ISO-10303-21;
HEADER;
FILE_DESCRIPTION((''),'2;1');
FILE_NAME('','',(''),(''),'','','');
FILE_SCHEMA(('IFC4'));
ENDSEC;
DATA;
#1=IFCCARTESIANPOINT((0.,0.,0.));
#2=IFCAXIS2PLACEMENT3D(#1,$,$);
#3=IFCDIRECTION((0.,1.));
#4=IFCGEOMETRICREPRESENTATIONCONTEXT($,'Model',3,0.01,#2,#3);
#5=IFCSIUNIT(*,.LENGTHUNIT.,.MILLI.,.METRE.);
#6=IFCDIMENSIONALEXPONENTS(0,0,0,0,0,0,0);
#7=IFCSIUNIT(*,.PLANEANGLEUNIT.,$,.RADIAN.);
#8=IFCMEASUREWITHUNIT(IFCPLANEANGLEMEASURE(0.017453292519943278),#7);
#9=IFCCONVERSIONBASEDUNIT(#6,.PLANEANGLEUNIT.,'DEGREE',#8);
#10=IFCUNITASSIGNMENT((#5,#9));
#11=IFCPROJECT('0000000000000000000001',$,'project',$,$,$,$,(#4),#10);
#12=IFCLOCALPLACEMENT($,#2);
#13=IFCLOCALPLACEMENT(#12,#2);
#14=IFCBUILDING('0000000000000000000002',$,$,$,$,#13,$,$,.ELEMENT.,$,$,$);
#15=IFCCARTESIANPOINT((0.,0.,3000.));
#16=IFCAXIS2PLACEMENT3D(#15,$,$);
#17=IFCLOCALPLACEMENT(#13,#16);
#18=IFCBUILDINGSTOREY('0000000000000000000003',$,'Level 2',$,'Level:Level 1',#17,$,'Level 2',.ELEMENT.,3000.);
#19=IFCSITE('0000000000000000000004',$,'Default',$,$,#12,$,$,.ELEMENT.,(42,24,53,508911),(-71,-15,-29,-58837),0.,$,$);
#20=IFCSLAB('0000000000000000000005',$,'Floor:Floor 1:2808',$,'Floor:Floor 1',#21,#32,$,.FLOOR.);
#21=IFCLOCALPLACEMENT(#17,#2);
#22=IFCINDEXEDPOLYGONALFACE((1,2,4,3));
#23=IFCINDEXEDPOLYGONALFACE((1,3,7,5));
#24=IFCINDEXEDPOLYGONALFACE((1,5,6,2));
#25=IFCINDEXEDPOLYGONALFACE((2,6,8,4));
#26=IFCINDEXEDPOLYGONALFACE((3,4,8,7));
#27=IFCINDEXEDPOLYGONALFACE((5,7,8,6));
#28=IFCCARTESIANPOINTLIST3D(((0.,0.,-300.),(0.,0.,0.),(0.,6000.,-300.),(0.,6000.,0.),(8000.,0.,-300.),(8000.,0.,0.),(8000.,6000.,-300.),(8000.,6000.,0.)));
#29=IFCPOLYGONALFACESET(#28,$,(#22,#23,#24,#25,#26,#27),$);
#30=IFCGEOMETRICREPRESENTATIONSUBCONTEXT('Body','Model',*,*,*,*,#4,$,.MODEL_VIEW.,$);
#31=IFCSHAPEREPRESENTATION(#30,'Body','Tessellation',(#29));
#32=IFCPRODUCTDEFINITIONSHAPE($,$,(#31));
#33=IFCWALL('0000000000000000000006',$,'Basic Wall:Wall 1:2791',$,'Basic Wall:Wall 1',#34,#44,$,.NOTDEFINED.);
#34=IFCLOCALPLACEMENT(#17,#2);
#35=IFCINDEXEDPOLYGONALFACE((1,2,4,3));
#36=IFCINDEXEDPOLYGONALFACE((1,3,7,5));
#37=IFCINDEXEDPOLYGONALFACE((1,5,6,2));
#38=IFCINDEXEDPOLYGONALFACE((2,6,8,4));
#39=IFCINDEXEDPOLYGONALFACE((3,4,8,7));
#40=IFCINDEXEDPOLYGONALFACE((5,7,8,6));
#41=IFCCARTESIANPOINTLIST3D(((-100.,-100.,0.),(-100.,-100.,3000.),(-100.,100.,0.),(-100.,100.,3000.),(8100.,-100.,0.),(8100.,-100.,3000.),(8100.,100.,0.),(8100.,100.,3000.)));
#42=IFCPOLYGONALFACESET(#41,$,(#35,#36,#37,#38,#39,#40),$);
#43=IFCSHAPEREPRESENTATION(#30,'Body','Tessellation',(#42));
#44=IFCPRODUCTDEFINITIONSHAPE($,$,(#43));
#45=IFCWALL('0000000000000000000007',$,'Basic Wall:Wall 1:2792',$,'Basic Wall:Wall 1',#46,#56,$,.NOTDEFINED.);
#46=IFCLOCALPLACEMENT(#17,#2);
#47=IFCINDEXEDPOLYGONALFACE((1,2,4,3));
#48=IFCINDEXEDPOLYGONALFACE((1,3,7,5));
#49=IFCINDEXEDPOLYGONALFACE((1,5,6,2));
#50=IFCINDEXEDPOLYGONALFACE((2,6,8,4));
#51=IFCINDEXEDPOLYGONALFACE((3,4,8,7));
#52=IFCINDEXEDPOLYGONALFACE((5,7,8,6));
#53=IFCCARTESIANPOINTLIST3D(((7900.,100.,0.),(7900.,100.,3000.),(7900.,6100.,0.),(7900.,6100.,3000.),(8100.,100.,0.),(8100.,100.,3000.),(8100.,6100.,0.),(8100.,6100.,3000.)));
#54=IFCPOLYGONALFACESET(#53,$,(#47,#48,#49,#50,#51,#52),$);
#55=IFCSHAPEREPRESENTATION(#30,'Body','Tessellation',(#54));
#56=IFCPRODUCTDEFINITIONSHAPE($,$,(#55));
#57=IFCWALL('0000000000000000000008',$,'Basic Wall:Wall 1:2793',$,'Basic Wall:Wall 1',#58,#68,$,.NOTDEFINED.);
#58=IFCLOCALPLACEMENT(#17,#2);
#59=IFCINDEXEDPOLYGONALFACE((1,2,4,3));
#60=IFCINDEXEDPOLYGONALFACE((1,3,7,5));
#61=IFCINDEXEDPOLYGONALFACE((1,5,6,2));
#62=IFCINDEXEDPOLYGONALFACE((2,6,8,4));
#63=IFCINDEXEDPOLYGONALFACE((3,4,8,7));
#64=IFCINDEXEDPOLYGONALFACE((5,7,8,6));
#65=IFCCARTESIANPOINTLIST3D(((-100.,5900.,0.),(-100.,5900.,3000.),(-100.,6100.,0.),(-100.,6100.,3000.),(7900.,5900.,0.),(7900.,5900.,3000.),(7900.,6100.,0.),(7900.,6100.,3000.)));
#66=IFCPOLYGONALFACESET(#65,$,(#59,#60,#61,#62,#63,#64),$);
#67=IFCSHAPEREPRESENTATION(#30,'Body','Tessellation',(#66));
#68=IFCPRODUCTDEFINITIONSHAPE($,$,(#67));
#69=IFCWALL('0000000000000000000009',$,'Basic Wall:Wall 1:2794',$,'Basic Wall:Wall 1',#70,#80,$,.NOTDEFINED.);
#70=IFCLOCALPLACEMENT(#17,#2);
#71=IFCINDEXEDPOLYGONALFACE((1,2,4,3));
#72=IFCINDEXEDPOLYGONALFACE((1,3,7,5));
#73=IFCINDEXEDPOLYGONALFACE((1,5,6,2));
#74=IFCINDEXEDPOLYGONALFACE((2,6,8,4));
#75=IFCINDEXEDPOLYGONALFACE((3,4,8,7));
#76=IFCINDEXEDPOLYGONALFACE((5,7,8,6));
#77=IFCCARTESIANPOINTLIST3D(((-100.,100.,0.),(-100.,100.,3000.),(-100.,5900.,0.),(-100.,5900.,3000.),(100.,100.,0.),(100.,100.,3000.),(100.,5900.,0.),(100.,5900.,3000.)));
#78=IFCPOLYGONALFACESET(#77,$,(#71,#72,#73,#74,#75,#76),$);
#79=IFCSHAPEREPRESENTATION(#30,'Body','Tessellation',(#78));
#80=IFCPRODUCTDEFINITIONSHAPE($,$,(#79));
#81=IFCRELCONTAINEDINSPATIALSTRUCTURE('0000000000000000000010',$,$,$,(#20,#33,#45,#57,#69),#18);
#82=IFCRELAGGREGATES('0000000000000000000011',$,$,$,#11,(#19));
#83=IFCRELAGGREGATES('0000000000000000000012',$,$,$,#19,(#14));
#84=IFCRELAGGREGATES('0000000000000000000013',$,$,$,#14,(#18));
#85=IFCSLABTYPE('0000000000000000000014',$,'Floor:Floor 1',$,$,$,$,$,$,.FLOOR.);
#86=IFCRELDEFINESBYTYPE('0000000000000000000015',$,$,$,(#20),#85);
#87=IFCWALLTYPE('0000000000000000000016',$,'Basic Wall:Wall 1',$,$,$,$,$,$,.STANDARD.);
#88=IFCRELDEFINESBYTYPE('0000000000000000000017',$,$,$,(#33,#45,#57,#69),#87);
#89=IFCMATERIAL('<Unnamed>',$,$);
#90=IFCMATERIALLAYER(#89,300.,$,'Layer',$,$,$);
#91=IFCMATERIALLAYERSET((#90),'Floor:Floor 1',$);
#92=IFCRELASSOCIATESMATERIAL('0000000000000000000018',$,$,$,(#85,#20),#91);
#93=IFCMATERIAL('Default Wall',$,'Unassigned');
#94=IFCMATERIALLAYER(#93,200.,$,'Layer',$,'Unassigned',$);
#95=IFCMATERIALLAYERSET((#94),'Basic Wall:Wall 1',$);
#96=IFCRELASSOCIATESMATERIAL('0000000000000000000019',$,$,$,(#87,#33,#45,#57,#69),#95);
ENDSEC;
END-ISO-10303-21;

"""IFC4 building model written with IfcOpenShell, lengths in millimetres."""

from ifc_helpers import new_model, entity, si_unit, converted_unit, direction, frame, frame_2d, origin, origin_2d_with_axis, place, context, subcontext, project, spatial, rectangle, extrude, material, layer, layer_set, layer_usage, type_object, element, save


model = new_model("IFC4")

# Units and contexts
model_context = context("Model", 3, precision=0.01, world=origin(), true_north=direction((0.0, 1.0)))
body_context = subcontext(model_context, "Body", "Model", "MODEL_VIEW")
ifc_project = project(units=[si_unit("LENGTHUNIT", "METRE", prefix="MILLI"), converted_unit("PLANEANGLEUNIT", "DEGREE", entity("IfcPlaneAngleMeasure", 0.017453292519943278), si_unit("PLANEANGLEUNIT", "RADIAN"), dimensions=[0, 0, 0, 0, 0, 0, 0])], contexts=[model_context])

# Site, building, storey
site_placement = place(None, origin())
site = spatial("IfcSite", under=ifc_project, at=site_placement, Name="Default", CompositionType="ELEMENT", RefLatitude=(42, 24, 53, 508911), RefLongitude=(-71, -15, -29, -58837), RefElevation=0.0)
building_placement = place(site_placement, origin())
building = spatial("IfcBuilding", under=site, at=building_placement, CompositionType="ELEMENT")
storey_placement = place(building_placement, frame((0.0, 0.0, 3000.0)))
storey = spatial("IfcBuildingStorey", under=building, at=storey_placement, Name="Level 2", ObjectType="Level:Level 1", LongName="Level 2", CompositionType="ELEMENT", Elevation=3000.0)

# Slab
ifc_material_1 = material(Name="<Unnamed>")
ifc_layer_1 = layer(ifc_material_1, 300.0, Name="Layer")
ifc_layer_set_1 = layer_set([ifc_layer_1], Name="Floor:Floor 1")
ifc_layer_usage_1 = layer_usage(ifc_layer_set_1, "AXIS3", "POSITIVE", 0.0)
slab_type = type_object("IfcSlabType", Name="Floor:Floor 1", PredefinedType="FLOOR", material=ifc_layer_set_1)
slab_placement = place(storey_placement, origin())
element("IfcSlab", 1, at=slab_placement, inside=storey, type_object=slab_type, material=ifc_layer_usage_1, Name="Floor:Floor 1:2808", ObjectType="Floor:Floor 1", PredefinedType="FLOOR", context=body_context, shape_type="SweptSolid", body=[
    extrude(rectangle(XDim=6000.0, YDim=8000.0, at=origin_2d_with_axis()), frame((4000.0, 3000.0, 0.0), z_axis=(0.0, 0.0, -1.0), x_axis=(0.0, 1.0, 0.0)), (0.0, 0.0, 1.0), 300.0),
])

# Walls
ifc_material_2 = material(Name="Default Wall", Category="Unassigned")
ifc_layer_2 = layer(ifc_material_2, 200.0, Name="Layer", Category="Unassigned")
ifc_layer_set_2 = layer_set([ifc_layer_2], Name="Basic Wall:Wall 1")
ifc_layer_usage_2 = layer_usage(ifc_layer_set_2, "AXIS2", "NEGATIVE", 100.0)
wall_type = type_object("IfcWallType", Name="Basic Wall:Wall 1", PredefinedType="STANDARD", material=ifc_layer_set_2)
wall_1_placement = place(storey_placement, frame((-100.0, 0.0, 0.0)))
element("IfcWall", 2, at=wall_1_placement, inside=storey, type_object=wall_type, material=ifc_layer_usage_2, Name="Basic Wall:Wall 1:2791", ObjectType="Basic Wall:Wall 1", PredefinedType="NOTDEFINED", context=body_context, shape_type="SweptSolid", body=[
    extrude(rectangle(XDim=8200.0, YDim=200.0, at=frame_2d((4100.0, 0.0), x_axis=(-1.0, 0.0))), origin(), (0.0, 0.0, 1.0), 3000.0),
])
ifc_layer_usage_3 = layer_usage(ifc_layer_set_2, "AXIS2", "NEGATIVE", 100.0)
wall_2_placement = place(storey_placement, frame((8000.0, 100.0, 0.0), z_axis=(0.0, 0.0, 1.0), x_axis=(0.0, 1.0, 0.0)))
element("IfcWall", 3, at=wall_2_placement, inside=storey, type_object=wall_type, material=ifc_layer_usage_3, Name="Basic Wall:Wall 1:2792", ObjectType="Basic Wall:Wall 1", PredefinedType="NOTDEFINED", context=body_context, shape_type="SweptSolid", body=[
    extrude(rectangle(XDim=6000.0, YDim=200.0, at=frame_2d((3000.0, 0.0), x_axis=(-1.0, 0.0))), origin(), (0.0, 0.0, 1.0), 3000.0),
])
ifc_layer_usage_4 = layer_usage(ifc_layer_set_2, "AXIS2", "NEGATIVE", 100.0)
wall_3_placement = place(storey_placement, frame((7900.0, 6000.0, 0.0), z_axis=(0.0, 0.0, 1.0), x_axis=(-1.0, 0.0, 0.0)))
element("IfcWall", 4, at=wall_3_placement, inside=storey, type_object=wall_type, material=ifc_layer_usage_4, Name="Basic Wall:Wall 1:2793", ObjectType="Basic Wall:Wall 1", PredefinedType="NOTDEFINED", context=body_context, shape_type="SweptSolid", body=[
    extrude(rectangle(XDim=8000.0, YDim=200.0, at=frame_2d((4000.0, 0.0), x_axis=(-1.0, 0.0))), origin(), (0.0, 0.0, 1.0), 3000.0),
])
ifc_layer_usage_5 = layer_usage(ifc_layer_set_2, "AXIS2", "NEGATIVE", 100.0)
wall_4_placement = place(storey_placement, frame((0.0, 5900.0, 0.0), z_axis=(0.0, 0.0, 1.0), x_axis=(0.0, -1.0, 0.0)))
element("IfcWall", 5, at=wall_4_placement, inside=storey, type_object=wall_type, material=ifc_layer_usage_5, Name="Basic Wall:Wall 1:2794", ObjectType="Basic Wall:Wall 1", PredefinedType="NOTDEFINED", context=body_context, shape_type="SweptSolid", body=[
    extrude(rectangle(XDim=5800.0, YDim=200.0, at=frame_2d((2900.0, 0.0), x_axis=(-1.0, 0.0))), origin(), (0.0, 0.0, 1.0), 3000.0),
])

save(model, "model.ifc")
